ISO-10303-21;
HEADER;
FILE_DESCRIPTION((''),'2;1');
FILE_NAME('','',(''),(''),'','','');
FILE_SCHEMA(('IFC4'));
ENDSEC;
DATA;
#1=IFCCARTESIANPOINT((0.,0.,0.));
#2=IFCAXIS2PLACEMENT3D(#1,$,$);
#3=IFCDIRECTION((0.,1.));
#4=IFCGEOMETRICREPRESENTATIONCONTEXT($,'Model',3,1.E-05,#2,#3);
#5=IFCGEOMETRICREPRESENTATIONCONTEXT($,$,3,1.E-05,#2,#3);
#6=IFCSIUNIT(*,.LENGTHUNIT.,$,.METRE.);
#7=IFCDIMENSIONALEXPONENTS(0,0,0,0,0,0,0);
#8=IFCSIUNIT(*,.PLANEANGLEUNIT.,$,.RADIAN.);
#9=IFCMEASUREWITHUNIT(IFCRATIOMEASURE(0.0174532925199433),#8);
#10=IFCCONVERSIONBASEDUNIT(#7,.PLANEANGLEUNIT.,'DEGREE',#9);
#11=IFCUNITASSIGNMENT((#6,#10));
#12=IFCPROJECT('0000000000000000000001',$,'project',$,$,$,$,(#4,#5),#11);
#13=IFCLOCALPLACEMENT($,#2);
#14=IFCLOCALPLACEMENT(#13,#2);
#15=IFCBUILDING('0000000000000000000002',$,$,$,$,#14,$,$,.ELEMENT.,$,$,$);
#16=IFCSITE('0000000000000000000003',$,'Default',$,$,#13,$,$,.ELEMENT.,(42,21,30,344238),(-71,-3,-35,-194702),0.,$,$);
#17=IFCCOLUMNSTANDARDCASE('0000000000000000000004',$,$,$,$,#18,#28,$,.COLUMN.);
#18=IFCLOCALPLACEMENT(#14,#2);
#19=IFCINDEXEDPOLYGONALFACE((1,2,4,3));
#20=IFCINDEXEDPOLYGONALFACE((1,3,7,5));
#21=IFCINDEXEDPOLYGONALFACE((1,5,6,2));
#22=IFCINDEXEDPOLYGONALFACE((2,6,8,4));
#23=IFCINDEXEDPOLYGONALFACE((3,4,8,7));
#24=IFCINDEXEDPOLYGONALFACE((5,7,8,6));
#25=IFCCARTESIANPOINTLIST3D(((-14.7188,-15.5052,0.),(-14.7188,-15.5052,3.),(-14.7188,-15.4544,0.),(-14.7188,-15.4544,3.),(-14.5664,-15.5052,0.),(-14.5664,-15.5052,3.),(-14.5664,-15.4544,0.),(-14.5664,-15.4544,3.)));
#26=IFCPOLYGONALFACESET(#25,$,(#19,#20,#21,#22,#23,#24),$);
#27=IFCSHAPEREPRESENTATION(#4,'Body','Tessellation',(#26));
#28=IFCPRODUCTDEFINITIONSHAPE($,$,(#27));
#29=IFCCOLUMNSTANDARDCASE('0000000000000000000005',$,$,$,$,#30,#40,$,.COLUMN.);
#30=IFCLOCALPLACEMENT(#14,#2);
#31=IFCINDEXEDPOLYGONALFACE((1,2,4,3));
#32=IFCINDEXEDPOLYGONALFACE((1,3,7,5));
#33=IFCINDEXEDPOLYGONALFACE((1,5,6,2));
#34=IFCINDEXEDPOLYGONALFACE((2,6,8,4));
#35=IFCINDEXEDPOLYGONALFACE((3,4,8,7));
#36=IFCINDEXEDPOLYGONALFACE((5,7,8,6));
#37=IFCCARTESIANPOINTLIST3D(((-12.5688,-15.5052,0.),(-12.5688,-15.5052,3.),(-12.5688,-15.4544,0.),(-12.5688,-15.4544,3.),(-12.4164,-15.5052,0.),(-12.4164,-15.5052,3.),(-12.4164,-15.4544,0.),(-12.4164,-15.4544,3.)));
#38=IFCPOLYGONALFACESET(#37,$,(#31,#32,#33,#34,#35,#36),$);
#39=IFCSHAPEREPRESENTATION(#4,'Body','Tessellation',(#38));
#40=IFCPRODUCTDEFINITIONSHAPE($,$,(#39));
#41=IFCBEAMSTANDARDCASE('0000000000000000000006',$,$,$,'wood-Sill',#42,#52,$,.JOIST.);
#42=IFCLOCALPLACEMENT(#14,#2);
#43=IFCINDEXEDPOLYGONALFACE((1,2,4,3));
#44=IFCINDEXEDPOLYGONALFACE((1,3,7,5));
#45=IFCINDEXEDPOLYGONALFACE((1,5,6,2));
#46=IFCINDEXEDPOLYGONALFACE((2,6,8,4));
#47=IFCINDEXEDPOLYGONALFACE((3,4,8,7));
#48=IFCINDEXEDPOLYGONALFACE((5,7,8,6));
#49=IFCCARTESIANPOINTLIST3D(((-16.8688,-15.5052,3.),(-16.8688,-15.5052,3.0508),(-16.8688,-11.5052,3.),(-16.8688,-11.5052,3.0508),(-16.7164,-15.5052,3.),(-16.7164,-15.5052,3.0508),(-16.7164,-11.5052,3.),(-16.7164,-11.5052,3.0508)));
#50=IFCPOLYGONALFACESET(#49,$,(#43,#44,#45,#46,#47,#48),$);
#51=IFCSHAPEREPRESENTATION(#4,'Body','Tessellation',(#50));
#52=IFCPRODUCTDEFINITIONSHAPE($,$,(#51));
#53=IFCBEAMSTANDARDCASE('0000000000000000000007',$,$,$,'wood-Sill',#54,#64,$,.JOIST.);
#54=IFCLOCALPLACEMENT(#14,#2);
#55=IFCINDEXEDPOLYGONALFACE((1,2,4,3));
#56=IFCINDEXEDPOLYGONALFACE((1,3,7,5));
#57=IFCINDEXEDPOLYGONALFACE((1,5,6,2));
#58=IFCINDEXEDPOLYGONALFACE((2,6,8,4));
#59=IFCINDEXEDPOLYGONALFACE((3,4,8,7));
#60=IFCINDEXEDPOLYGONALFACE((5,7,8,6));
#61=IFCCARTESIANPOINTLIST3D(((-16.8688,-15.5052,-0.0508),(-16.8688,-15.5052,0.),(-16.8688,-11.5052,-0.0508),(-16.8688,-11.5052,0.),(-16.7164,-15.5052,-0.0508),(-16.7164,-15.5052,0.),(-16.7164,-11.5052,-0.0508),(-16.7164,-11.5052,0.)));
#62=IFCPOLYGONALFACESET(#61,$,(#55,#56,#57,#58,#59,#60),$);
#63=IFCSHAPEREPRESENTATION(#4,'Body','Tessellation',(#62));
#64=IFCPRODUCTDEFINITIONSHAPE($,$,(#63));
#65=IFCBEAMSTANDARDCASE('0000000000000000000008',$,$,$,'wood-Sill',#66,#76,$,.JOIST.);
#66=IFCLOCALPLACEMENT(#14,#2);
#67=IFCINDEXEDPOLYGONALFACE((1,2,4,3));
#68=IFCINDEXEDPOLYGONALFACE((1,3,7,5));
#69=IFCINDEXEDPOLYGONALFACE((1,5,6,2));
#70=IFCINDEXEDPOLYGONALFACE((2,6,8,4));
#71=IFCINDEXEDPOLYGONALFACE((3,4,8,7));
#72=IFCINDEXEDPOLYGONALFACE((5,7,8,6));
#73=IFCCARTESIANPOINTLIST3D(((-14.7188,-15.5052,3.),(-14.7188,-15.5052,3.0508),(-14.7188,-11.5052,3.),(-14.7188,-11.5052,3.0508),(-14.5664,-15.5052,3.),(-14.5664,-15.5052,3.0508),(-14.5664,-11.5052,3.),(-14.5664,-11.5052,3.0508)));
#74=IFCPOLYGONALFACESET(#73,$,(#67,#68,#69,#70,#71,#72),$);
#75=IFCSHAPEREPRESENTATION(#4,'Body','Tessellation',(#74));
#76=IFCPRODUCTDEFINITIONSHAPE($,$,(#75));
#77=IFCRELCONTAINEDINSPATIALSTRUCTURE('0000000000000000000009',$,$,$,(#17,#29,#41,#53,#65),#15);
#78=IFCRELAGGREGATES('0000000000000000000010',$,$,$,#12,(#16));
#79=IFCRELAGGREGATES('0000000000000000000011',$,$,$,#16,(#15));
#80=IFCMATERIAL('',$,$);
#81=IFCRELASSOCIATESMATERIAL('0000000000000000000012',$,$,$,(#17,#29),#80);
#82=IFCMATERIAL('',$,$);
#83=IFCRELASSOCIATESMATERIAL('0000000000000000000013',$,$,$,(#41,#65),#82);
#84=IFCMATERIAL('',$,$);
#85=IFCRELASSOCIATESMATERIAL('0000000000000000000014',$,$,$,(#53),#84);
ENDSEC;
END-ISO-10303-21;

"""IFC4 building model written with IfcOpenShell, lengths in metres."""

from ifc_helpers import new_model, entity, si_unit, converted_unit, direction, frame, origin, place, context, project, spatial, rectangle, extrude, material, element, save


model = new_model("IFC4")

# Units and contexts
model_context = context("Model", 3, precision=1e-05, world=origin(), true_north=direction((0.0, 1.0)))
context_of_model = context(None, 3, precision=1e-05, world=origin(), true_north=direction((0.0, 1.0)))
ifc_project = project(units=[si_unit("LENGTHUNIT", "METRE"), converted_unit("PLANEANGLEUNIT", "DEGREE", entity("IfcRatioMeasure", 0.0174532925199433), si_unit("PLANEANGLEUNIT", "RADIAN"), dimensions=[0, 0, 0, 0, 0, 0, 0])], contexts=[model_context, context_of_model])

# Site, building
site_placement = place(None, origin())
site = spatial("IfcSite", under=ifc_project, at=site_placement, Name="Default", CompositionType="ELEMENT", RefLatitude=(42, 21, 30, 344238), RefLongitude=(-71, -3, -35, -194702), RefElevation=0.0)
building_placement = place(site_placement, origin())
building = spatial("IfcBuilding", under=site, at=building_placement, CompositionType="ELEMENT")

# Columns
ifc_material_1 = material(Name="")
placement_1 = place(building_placement, origin())
placement_2 = place(placement_1, frame((-14.6426, -15.5052, 0.0), z_axis=(0.0, 0.0, 1.0), x_axis=(0.0, 1.0, 0.0)))
for number, where, z_axis, x_axis in (
    (1, (0.0254, 0.0, 0.0), (0.0, 0.0, 1.0), (1.0, 0.0, 0.0)),
):
    element("IfcColumnStandardCase", number, at=place(placement_2, frame(where, z_axis=z_axis, x_axis=x_axis)), inside=building, material=ifc_material_1, PredefinedType="COLUMN", context=model_context, shape_type="SweptSolid", body=[
        extrude(rectangle(XDim=0.0508, YDim=0.1524), origin(), (0.0, 0.0, 1.0), 3.0),
    ])
placement_3 = place(placement_1, frame((-12.4926, -15.5052, 0.0), z_axis=(0.0, 0.0, 1.0), x_axis=(0.0, 1.0, 0.0)))
for number, where, z_axis, x_axis in (
    (2, (0.0254, 0.0, 0.0), (0.0, 0.0, 1.0), (1.0, 0.0, 0.0)),
):
    element("IfcColumnStandardCase", number, at=place(placement_3, frame(where, z_axis=z_axis, x_axis=x_axis)), inside=building, material=ifc_material_1, PredefinedType="COLUMN", context=model_context, shape_type="SweptSolid", body=[
        extrude(rectangle(XDim=0.0508, YDim=0.1524), origin(), (0.0, 0.0, 1.0), 3.0),
    ])

# Beams
ifc_material_2 = material(Name="")
placement_4 = place(placement_1, frame((-16.7926, -15.5052, 0.0), z_axis=(0.0, 0.0, 1.0), x_axis=(0.0, 1.0, 0.0)))
beam_1_placement = place(placement_4, frame((2.0, 0.0, 3.0), z_axis=(0.0, 0.0, 1.0), x_axis=(1.0, 0.0, 0.0)))
element("IfcBeamStandardCase", 3, at=beam_1_placement, inside=building, material=ifc_material_2, ObjectType="wood-Sill", PredefinedType="JOIST", context=model_context, shape_type="SweptSolid", body=[
    extrude(rectangle(XDim=4.0, YDim=0.1524), origin(), (0.0, 0.0, 1.0), 0.0508),
])
ifc_material_3 = material(Name="")
beam_2_placement = place(placement_4, frame((2.0, 0.0, -0.0508), z_axis=(0.0, 0.0, 1.0), x_axis=(1.0, 0.0, 0.0)))
element("IfcBeamStandardCase", 4, at=beam_2_placement, inside=building, material=ifc_material_3, ObjectType="wood-Sill", PredefinedType="JOIST", context=model_context, shape_type="SweptSolid", body=[
    extrude(rectangle(XDim=4.0, YDim=0.1524), origin(), (0.0, 0.0, 1.0), 0.0508),
])
beam_3_placement = place(placement_2, frame((2.0, 0.0, 3.0), z_axis=(0.0, 0.0, 1.0), x_axis=(1.0, 0.0, 0.0)))
element("IfcBeamStandardCase", 5, at=beam_3_placement, inside=building, material=ifc_material_2, ObjectType="wood-Sill", PredefinedType="JOIST", context=model_context, shape_type="SweptSolid", body=[
    extrude(rectangle(XDim=4.0, YDim=0.1524), origin(), (0.0, 0.0, 1.0), 0.0508),
])

save(model, "model.ifc")
